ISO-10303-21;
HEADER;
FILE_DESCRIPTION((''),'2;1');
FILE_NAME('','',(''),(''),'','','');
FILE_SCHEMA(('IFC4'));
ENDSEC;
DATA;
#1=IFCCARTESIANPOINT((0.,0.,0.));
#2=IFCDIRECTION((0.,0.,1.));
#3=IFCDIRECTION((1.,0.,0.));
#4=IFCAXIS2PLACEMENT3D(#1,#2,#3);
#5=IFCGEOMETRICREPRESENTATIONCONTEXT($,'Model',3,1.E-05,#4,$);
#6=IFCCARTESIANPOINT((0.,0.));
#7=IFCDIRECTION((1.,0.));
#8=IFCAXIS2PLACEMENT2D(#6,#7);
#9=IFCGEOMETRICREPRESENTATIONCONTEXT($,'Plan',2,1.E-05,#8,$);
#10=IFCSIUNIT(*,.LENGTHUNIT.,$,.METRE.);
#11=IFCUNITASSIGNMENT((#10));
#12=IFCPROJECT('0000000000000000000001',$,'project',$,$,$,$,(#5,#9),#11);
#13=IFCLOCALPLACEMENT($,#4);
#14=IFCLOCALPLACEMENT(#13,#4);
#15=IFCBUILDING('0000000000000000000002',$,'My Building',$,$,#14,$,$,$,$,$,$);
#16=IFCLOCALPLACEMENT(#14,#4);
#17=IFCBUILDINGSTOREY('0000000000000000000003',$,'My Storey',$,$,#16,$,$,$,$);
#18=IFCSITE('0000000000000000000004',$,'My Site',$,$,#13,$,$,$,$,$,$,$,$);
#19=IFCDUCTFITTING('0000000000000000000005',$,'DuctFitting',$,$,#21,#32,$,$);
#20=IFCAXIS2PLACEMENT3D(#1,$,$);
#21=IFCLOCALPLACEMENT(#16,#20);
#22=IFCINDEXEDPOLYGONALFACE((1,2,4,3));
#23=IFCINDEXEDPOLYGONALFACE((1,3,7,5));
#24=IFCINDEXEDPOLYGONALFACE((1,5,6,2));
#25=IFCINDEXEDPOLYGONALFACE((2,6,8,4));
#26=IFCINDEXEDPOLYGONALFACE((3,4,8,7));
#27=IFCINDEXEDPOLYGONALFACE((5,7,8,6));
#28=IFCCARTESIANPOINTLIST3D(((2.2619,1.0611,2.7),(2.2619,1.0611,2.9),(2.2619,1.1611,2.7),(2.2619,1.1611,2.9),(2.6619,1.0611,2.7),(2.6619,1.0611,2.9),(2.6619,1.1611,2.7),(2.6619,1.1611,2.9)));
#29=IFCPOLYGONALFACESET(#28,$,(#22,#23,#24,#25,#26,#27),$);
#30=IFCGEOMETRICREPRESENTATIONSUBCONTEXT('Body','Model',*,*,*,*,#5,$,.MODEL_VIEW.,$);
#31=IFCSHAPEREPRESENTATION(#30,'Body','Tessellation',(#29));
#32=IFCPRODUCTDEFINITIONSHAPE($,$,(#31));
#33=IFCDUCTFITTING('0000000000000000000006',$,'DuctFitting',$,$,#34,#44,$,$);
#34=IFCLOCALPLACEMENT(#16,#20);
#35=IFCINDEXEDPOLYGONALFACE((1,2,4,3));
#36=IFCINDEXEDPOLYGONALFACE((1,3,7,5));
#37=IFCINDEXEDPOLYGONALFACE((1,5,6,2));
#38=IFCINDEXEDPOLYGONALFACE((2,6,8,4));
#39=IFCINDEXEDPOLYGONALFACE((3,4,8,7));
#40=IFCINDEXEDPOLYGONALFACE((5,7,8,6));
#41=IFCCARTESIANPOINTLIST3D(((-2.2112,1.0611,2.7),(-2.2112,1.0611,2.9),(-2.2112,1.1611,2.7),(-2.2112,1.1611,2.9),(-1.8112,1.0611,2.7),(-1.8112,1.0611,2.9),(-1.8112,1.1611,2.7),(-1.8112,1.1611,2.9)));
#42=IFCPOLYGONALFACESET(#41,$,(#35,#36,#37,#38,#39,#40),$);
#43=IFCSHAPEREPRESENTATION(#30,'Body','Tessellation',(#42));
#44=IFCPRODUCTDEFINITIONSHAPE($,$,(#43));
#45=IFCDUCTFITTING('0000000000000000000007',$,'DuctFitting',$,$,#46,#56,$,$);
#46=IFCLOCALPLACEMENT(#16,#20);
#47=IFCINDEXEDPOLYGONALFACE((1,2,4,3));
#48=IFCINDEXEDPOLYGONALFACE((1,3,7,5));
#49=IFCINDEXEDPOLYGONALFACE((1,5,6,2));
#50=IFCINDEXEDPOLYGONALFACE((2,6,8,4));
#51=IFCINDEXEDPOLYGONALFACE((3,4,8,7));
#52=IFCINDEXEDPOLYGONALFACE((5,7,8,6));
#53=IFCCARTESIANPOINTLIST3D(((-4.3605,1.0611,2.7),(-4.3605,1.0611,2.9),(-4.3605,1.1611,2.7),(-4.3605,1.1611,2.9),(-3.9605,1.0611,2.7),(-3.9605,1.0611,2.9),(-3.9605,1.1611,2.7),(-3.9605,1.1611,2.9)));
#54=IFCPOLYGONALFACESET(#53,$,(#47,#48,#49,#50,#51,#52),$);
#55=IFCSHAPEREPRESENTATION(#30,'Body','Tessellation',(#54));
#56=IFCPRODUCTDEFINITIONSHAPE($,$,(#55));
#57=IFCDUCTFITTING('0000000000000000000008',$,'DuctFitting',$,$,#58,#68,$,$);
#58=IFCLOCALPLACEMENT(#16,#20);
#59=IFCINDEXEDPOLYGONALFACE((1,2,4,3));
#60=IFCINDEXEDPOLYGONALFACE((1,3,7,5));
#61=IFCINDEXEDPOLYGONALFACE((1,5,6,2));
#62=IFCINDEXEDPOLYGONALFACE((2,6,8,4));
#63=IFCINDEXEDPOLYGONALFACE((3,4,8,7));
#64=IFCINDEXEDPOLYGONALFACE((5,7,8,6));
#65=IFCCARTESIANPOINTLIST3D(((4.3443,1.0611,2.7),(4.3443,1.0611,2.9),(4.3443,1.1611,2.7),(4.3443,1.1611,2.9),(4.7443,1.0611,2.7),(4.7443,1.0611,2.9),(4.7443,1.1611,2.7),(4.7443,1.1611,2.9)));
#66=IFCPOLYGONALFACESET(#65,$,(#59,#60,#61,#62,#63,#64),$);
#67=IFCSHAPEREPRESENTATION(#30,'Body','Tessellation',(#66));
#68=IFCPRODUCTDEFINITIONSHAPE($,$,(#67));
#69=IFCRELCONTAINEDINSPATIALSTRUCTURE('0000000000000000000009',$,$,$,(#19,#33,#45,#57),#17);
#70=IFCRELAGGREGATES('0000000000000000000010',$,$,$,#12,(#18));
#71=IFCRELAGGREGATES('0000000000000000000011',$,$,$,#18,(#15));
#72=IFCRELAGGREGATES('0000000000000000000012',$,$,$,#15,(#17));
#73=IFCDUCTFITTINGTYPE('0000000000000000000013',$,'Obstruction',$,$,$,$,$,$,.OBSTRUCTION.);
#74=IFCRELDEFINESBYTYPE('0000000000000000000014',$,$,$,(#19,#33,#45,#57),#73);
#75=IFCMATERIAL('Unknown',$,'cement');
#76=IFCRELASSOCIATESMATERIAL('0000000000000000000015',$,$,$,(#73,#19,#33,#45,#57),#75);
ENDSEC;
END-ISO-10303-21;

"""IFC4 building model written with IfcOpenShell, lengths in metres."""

from ifc_helpers import new_model, si_unit, frame, origin_with_axes, origin_2d_with_axis, place, context, subcontext, project, spatial, rectangle, extrude, material, material_profile, profile_set, profile_usage, type_object, element, save


model = new_model("IFC4")

# Units and contexts
model_context = context("Model", 3, precision=1e-05, world=origin_with_axes())
plan_context = context("Plan", 2, precision=1e-05, world=origin_2d_with_axis())
body_context = subcontext(model_context, "Body", "Model", "MODEL_VIEW")
ifc_project = project(units=[si_unit("LENGTHUNIT", "METRE")], contexts=[model_context, plan_context])

# Site, building, storey
site_placement = place(None, origin_with_axes())
site = spatial("IfcSite", under=ifc_project, at=site_placement, Name="My Site")
building_placement = place(site_placement, origin_with_axes())
building = spatial("IfcBuilding", under=site, at=building_placement, Name="My Building")
storey_placement = place(building_placement, origin_with_axes())
storey = spatial("IfcBuildingStorey", under=building, at=storey_placement, Name="My Storey")

# Shared definitions
ifc_material = material(Name="Unknown", Category="cement")

# Duct fittings
ifc_material_profile_1 = material_profile(ifc_material, rectangle(XDim=0.4, YDim=0.2))
ifc_profile_set_1 = profile_set([ifc_material_profile_1])
ifc_profile_usage_1 = profile_usage(ifc_profile_set_1, cardinal=5)
duct_fitting_type_1 = type_object("IfcDuctFittingType", Name="Obstruction", PredefinedType="OBSTRUCTION", material=ifc_profile_set_1)
duct_fitting_1_placement = place(storey_placement, frame((2.4619, 1.0611, 2.8), z_axis=(0.0, 1.0, 0.0), x_axis=(-1.0, 0.0, 0.0)))
element("IfcDuctFitting", 1, at=duct_fitting_1_placement, inside=storey, type_object=duct_fitting_type_1, material=ifc_profile_usage_1, Name="DuctFitting", context=body_context, shape_type="SweptSolid", body=[
    extrude(rectangle(XDim=0.4, YDim=0.2), origin_with_axes(), (0.0, 0.0, 1.0), 0.1),
])
ifc_profile_usage_2 = profile_usage(ifc_profile_set_1, cardinal=5)
duct_fitting_2_placement = place(storey_placement, frame((-2.0112, 1.0611, 2.8), z_axis=(0.0, 1.0, 0.0), x_axis=(-1.0, 0.0, 0.0)))
element("IfcDuctFitting", 2, at=duct_fitting_2_placement, inside=storey, type_object=duct_fitting_type_1, material=ifc_profile_usage_2, Name="DuctFitting", context=body_context, shape_type="SweptSolid", body=[
    extrude(rectangle(XDim=0.4, YDim=0.2), origin_with_axes(), (0.0, 0.0, 1.0), 0.1),
])
ifc_profile_usage_3 = profile_usage(ifc_profile_set_1, cardinal=5)
duct_fitting_3_placement = place(storey_placement, frame((-4.1605, 1.0611, 2.8), z_axis=(0.0, 1.0, 0.0), x_axis=(-1.0, 0.0, 0.0)))
element("IfcDuctFitting", 3, at=duct_fitting_3_placement, inside=storey, type_object=duct_fitting_type_1, material=ifc_profile_usage_3, Name="DuctFitting", context=body_context, shape_type="SweptSolid", body=[
    extrude(rectangle(XDim=0.4, YDim=0.2), origin_with_axes(), (0.0, 0.0, 1.0), 0.1),
])
ifc_profile_usage_4 = profile_usage(ifc_profile_set_1, cardinal=5)
duct_fitting_4_placement = place(storey_placement, frame((4.5443, 1.0611, 2.8), z_axis=(0.0, 1.0, 0.0), x_axis=(-1.0, 0.0, 0.0)))
element("IfcDuctFitting", 4, at=duct_fitting_4_placement, inside=storey, type_object=duct_fitting_type_1, material=ifc_profile_usage_4, Name="DuctFitting", context=body_context, shape_type="SweptSolid", body=[
    extrude(rectangle(XDim=0.4, YDim=0.2), origin_with_axes(), (0.0, 0.0, 1.0), 0.1),
])

save(model, "model.ifc")
